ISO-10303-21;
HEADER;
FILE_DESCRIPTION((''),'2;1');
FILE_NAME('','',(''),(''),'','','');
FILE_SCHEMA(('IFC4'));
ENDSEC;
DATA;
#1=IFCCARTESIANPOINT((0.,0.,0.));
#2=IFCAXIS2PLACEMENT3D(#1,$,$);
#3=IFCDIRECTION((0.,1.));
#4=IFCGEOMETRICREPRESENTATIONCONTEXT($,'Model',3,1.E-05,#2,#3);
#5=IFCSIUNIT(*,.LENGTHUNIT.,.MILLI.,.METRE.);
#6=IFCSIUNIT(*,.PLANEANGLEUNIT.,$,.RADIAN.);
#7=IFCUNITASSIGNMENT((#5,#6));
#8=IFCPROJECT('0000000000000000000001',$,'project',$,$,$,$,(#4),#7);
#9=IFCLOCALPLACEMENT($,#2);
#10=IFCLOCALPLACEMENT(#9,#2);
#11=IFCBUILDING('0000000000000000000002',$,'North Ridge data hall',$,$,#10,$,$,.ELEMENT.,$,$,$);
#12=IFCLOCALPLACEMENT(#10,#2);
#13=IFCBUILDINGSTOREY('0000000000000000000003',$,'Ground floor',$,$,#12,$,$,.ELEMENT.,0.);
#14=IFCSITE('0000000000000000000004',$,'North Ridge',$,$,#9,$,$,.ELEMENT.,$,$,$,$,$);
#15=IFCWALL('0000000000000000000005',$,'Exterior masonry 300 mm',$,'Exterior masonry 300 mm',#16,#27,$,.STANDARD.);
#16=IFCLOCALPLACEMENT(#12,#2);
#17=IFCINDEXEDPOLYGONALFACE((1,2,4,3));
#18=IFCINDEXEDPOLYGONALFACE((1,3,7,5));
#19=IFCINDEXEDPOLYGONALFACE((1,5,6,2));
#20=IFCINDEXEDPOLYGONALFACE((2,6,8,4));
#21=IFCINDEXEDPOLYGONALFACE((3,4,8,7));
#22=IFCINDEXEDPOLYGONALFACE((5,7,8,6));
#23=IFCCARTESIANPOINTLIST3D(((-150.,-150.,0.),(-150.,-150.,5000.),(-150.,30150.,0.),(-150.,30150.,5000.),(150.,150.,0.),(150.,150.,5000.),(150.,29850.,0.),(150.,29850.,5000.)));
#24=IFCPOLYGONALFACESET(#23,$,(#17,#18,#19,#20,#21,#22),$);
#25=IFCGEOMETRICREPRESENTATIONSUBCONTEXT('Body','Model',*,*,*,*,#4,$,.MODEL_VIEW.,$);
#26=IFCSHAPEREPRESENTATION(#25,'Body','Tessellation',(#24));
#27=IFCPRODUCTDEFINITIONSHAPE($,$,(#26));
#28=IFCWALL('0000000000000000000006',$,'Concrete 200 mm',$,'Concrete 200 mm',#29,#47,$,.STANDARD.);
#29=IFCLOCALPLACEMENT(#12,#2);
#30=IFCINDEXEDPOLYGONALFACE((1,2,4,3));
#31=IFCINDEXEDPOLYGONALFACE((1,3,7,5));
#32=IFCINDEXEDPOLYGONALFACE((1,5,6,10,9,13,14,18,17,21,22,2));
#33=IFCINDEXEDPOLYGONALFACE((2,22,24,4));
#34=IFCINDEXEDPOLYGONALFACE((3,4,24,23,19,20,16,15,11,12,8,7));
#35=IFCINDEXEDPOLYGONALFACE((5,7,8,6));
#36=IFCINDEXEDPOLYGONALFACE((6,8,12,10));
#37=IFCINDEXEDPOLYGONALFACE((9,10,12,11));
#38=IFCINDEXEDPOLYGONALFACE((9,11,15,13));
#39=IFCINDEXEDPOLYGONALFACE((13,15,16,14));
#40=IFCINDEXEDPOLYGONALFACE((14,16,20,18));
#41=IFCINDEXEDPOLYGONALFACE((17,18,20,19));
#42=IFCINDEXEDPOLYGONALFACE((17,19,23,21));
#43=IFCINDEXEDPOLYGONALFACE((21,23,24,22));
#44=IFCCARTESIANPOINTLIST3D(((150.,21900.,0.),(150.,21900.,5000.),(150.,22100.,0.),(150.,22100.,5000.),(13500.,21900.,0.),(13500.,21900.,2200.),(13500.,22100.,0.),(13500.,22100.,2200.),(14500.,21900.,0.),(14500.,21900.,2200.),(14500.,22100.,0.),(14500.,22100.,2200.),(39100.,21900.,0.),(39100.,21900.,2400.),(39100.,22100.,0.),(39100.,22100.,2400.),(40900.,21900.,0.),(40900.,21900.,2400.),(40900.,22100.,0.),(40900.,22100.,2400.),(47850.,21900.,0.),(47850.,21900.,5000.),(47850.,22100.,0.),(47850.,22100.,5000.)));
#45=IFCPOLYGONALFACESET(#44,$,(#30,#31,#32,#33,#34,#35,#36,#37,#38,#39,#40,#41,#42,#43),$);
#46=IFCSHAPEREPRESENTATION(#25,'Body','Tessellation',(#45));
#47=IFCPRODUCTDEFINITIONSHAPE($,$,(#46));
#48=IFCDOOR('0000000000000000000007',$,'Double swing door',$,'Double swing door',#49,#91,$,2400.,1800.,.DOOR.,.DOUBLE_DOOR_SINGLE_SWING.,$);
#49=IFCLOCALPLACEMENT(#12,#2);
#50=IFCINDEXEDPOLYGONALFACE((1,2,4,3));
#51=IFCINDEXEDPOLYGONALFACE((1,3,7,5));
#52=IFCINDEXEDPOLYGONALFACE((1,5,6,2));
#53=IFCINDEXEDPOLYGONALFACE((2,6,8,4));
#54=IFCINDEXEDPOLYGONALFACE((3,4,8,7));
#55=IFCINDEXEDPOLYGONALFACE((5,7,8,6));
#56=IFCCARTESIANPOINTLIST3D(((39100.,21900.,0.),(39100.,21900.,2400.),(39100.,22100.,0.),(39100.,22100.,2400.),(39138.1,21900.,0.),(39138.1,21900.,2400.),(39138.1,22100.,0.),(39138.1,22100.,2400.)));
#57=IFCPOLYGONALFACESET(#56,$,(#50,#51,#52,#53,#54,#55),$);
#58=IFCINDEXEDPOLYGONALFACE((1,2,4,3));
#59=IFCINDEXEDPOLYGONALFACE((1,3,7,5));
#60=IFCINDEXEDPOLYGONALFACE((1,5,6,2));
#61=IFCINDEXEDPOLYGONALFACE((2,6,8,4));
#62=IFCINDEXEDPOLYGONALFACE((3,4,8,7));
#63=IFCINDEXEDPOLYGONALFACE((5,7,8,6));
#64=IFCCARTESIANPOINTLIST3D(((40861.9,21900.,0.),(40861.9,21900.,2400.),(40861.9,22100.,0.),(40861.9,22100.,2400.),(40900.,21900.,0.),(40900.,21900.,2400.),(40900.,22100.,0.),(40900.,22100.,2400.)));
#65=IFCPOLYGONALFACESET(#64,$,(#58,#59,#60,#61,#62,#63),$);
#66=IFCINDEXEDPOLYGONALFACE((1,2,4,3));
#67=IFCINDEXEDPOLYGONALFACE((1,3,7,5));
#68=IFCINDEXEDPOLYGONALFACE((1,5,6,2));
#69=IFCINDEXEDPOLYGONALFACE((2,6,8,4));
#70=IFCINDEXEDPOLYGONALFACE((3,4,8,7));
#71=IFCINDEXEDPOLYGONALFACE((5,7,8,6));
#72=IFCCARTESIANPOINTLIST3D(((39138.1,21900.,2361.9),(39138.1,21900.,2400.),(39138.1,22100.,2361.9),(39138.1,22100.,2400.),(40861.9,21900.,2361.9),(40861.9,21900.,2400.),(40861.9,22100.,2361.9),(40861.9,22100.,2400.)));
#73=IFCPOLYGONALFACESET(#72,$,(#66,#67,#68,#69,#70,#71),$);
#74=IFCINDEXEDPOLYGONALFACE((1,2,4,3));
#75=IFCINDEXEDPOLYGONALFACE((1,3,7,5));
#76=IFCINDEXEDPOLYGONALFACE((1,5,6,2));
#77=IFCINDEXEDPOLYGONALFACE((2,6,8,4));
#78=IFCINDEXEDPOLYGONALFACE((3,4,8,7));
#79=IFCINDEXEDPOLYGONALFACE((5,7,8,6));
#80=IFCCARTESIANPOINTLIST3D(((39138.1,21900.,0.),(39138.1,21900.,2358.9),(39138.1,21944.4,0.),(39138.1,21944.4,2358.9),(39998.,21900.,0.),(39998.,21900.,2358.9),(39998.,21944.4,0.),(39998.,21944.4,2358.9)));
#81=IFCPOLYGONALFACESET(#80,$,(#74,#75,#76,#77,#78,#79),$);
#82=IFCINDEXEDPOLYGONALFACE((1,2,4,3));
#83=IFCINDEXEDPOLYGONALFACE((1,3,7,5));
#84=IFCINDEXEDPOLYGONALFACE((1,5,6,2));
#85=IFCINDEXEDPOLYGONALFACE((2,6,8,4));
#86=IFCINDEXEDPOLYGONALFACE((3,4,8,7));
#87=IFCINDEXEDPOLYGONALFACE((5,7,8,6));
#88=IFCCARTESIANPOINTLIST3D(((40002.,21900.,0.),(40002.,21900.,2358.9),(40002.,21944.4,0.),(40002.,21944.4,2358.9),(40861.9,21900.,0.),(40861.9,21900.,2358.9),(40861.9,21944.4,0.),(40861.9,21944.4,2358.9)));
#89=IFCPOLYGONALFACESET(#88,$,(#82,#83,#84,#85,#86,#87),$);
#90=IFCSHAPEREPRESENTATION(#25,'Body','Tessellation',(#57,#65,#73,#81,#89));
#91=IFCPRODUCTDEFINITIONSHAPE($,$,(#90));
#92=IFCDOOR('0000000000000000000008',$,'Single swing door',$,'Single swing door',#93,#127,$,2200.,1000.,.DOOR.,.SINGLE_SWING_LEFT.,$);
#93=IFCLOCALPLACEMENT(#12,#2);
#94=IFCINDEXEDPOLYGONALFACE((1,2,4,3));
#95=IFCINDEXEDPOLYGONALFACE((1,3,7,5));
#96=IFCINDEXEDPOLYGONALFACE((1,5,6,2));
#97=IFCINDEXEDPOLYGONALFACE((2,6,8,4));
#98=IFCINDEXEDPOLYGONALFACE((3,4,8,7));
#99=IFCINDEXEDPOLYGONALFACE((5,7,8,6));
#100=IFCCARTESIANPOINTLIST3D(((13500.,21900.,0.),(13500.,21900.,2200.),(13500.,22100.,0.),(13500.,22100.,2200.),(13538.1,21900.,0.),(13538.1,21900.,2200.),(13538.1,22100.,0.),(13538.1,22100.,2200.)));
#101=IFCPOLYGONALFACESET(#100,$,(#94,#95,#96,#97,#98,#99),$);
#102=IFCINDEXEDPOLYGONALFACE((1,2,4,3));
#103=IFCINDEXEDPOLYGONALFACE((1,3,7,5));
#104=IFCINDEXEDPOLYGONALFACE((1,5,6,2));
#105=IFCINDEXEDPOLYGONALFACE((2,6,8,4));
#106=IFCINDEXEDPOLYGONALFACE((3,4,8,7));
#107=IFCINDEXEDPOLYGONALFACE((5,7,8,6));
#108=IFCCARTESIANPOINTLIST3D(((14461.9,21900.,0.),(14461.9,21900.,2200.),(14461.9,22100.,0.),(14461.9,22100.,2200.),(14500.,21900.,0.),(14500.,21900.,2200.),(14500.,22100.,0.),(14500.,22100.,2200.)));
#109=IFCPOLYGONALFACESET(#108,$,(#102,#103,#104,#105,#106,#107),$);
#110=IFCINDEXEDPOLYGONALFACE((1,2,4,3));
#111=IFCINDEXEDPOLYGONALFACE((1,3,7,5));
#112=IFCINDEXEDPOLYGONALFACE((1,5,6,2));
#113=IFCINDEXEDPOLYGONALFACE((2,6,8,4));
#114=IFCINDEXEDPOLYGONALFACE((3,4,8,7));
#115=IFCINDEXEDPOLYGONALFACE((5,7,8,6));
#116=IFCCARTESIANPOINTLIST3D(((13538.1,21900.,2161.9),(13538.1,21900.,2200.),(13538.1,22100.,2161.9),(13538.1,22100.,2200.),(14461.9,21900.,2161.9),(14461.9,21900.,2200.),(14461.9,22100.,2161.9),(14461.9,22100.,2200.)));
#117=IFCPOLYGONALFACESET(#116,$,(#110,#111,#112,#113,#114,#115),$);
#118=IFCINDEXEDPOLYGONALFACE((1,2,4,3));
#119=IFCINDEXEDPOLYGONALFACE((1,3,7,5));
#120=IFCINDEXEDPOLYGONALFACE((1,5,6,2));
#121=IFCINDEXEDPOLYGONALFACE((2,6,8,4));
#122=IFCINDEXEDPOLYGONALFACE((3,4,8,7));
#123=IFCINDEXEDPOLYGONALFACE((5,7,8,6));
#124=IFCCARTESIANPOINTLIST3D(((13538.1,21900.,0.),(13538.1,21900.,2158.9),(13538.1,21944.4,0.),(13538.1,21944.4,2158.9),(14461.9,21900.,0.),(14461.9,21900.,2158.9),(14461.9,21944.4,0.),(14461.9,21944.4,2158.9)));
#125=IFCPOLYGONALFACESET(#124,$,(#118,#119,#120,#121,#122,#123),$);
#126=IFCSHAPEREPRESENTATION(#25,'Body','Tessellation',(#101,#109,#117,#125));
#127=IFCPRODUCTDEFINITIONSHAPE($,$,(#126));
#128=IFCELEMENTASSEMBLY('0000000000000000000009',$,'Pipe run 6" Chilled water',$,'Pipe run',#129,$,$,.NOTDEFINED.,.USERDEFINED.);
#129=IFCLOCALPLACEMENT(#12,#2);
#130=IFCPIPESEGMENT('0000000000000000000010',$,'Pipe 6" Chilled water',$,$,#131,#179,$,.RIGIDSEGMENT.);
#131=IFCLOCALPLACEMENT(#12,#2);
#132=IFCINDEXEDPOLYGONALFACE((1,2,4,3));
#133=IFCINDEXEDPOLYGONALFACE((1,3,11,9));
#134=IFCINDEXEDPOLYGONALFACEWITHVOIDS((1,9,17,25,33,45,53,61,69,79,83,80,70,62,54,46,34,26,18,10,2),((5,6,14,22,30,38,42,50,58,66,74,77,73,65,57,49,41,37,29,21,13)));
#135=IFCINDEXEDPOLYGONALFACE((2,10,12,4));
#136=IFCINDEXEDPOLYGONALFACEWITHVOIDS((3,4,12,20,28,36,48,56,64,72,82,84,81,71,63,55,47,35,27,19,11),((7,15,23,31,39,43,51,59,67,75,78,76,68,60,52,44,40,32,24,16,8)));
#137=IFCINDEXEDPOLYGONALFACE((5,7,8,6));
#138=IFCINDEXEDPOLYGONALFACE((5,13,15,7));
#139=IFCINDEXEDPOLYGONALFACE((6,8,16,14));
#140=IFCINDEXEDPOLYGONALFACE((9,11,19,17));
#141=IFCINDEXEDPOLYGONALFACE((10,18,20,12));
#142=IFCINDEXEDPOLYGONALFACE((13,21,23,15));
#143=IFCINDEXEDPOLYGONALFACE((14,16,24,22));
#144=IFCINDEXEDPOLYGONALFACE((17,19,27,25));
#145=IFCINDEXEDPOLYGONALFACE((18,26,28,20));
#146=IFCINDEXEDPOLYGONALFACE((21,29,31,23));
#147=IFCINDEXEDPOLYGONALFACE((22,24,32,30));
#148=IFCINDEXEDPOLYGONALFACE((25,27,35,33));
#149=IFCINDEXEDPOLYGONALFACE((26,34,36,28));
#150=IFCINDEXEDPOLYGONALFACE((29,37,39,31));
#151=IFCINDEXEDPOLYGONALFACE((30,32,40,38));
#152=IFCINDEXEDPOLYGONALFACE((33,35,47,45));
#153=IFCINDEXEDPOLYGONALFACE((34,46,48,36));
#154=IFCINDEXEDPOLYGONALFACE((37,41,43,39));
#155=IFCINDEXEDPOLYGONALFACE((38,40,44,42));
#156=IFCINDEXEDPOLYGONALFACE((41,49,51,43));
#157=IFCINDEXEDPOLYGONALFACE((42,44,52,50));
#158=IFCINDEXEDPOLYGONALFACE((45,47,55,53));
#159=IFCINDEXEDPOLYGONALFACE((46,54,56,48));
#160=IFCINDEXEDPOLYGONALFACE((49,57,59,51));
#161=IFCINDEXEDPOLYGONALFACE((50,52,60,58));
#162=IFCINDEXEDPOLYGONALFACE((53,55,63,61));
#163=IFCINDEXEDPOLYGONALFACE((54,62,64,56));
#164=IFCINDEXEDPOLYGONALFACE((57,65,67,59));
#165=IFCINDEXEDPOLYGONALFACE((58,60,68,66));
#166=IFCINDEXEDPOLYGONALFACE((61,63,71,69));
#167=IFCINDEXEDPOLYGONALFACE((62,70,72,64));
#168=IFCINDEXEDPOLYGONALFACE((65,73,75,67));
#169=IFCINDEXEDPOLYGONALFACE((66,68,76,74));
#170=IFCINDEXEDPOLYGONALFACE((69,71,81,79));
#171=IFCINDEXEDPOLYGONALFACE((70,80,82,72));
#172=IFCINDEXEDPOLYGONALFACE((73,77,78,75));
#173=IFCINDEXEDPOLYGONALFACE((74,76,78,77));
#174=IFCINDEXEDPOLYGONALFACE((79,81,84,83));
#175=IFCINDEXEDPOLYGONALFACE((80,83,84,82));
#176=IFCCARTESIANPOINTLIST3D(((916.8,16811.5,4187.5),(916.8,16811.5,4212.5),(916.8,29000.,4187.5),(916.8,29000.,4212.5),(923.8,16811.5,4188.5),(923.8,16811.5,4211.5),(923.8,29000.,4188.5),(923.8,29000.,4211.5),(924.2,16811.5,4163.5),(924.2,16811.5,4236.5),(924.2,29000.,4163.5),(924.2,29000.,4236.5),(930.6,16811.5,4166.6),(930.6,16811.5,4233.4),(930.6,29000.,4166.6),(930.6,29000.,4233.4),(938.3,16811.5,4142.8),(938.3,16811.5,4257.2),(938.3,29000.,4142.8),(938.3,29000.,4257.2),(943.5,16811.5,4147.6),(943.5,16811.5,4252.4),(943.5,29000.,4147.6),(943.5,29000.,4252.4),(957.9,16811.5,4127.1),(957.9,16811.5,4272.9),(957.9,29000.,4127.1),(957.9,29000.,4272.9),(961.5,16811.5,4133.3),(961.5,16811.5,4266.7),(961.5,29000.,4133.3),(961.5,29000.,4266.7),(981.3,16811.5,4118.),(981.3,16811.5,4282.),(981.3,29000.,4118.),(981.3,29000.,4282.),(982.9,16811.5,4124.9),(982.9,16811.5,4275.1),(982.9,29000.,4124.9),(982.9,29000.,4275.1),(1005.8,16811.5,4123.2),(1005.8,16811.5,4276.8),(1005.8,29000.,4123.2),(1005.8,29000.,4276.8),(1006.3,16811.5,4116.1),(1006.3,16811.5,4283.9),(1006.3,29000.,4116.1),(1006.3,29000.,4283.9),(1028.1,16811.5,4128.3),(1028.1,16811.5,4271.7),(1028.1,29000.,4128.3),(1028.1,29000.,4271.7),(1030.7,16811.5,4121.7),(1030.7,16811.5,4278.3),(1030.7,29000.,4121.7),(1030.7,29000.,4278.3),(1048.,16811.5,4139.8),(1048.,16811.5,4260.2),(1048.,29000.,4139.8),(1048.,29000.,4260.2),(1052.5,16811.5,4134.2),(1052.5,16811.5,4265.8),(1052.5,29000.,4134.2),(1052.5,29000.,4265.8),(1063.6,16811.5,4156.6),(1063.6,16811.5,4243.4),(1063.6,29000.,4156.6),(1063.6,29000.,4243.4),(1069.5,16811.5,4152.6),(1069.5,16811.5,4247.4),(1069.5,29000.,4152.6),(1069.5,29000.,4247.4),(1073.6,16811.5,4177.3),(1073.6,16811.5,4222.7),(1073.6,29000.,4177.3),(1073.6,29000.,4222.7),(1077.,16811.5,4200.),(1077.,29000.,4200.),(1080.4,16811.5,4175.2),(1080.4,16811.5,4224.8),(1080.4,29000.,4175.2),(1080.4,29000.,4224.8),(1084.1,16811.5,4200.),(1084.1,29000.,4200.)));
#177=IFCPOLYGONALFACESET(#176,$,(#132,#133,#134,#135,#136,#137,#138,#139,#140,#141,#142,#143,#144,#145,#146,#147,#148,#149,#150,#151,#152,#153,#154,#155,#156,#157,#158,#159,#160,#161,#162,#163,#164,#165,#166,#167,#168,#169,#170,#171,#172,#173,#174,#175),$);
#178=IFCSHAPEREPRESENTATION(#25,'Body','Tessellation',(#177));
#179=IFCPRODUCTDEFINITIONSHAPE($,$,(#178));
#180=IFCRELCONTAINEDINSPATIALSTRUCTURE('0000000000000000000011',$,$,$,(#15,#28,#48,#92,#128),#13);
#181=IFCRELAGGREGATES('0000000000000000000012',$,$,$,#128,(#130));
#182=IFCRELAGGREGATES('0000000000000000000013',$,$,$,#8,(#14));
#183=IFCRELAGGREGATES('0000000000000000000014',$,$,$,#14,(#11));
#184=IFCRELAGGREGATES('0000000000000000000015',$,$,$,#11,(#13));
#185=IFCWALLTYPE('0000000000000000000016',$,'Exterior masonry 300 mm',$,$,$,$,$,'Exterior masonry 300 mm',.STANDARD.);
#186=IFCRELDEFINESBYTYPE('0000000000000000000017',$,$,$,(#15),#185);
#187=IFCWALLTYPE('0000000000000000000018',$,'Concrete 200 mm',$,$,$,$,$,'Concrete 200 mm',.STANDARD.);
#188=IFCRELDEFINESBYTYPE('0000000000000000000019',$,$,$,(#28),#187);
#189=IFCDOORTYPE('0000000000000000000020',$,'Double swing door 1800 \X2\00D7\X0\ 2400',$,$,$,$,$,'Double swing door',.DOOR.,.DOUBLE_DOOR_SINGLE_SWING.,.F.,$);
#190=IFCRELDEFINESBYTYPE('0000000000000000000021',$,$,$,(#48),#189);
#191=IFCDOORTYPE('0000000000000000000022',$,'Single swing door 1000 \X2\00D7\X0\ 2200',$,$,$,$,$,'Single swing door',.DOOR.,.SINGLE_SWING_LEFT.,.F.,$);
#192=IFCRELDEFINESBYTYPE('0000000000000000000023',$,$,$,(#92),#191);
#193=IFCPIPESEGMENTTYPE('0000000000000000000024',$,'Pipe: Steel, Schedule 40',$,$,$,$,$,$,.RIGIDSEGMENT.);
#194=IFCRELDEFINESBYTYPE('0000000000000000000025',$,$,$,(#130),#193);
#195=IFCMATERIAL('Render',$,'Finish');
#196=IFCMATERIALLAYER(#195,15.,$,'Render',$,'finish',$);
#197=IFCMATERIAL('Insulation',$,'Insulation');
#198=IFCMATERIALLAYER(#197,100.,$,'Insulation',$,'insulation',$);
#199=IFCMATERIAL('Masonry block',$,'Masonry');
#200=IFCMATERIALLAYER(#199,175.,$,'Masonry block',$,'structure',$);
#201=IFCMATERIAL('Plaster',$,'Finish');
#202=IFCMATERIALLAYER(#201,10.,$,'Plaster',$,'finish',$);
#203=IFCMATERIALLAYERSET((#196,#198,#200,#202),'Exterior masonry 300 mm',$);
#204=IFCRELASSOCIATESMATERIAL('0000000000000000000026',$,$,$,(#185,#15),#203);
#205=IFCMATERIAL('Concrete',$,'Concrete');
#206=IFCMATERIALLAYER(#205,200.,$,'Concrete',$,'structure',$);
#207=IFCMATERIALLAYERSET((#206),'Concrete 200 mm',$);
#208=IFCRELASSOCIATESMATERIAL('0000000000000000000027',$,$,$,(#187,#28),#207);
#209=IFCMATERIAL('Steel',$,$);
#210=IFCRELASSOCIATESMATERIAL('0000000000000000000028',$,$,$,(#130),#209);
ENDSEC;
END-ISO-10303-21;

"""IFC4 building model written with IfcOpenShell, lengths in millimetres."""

from ifc_helpers import new_model, si_unit, direction, frame, origin, origin_with_axes, origin_2d, place, context, subcontext, project, spatial, polyline, hollow_circle, outline, extrude, material, layer, layer_set, layer_usage, type_object, element, fill, aggregate, save


model = new_model("IFC4")

# Units and contexts
model_context = context("Model", 3, precision=1e-05, world=origin(), true_north=direction((0.0, 1.0)))
body_context = subcontext(model_context, "Body", "Model", "MODEL_VIEW")
ifc_project = project(units=[si_unit("LENGTHUNIT", "METRE", prefix="MILLI"), si_unit("PLANEANGLEUNIT", "RADIAN")], contexts=[model_context])

# Site, building, storey
site_placement = place(None, origin())
site = spatial("IfcSite", under=ifc_project, at=site_placement, Name="North Ridge", CompositionType="ELEMENT")
building_placement = place(site_placement, origin())
building = spatial("IfcBuilding", under=site, at=building_placement, Name="North Ridge data hall", CompositionType="ELEMENT")
storey_placement = place(building_placement, origin())
storey = spatial("IfcBuildingStorey", under=building, at=storey_placement, Name="Ground floor", CompositionType="ELEMENT", Elevation=0.0)

# Wall
ifc_material_1 = material(Name="Render", Category="Finish")
ifc_layer_1 = layer(ifc_material_1, 15.0, Name="Render", Category="finish")
ifc_material_2 = material(Name="Insulation", Category="Insulation")
ifc_layer_2 = layer(ifc_material_2, 100.0, Name="Insulation", Category="insulation")
ifc_material_3 = material(Name="Masonry block", Category="Masonry")
ifc_layer_3 = layer(ifc_material_3, 175.0, Name="Masonry block", Category="structure")
ifc_material_4 = material(Name="Plaster", Category="Finish")
ifc_layer_4 = layer(ifc_material_4, 10.0, Name="Plaster", Category="finish")
ifc_layer_set_1 = layer_set([ifc_layer_1, ifc_layer_2, ifc_layer_3, ifc_layer_4], Name="Exterior masonry 300 mm")
ifc_layer_usage_1 = layer_usage(ifc_layer_set_1, "AXIS2", "POSITIVE", -150.0)
wall_type_1 = type_object("IfcWallType", Name="Exterior masonry 300 mm", ElementType="Exterior masonry 300 mm", PredefinedType="STANDARD", material=ifc_layer_set_1)
wall_1_placement = place(storey_placement, frame((0.0, 30000.0, 0.0), z_axis=(0.0, 0.0, 1.0), x_axis=(0.0, -1.0, 0.0)))
element("IfcWall", 1, at=wall_1_placement, inside=storey, type_object=wall_type_1, material=ifc_layer_usage_1, Name="Exterior masonry 300 mm", ObjectType="Exterior masonry 300 mm", PredefinedType="STANDARD", context=body_context, shape_type="SweptSolid", body=[
    extrude(outline(polyline([(-150.0, -150.0), (30150.0, -150.0), (29850.0, 150.0), (150.0, 150.0), (-150.0, -150.0)])), origin(), (0.0, 0.0, 1.0), 5000.0),
])

# Wall, openings, doors
ifc_material_5 = material(Name="Concrete", Category="Concrete")
ifc_layer_5 = layer(ifc_material_5, 200.0, Name="Concrete", Category="structure")
ifc_layer_set_2 = layer_set([ifc_layer_5], Name="Concrete 200 mm")
ifc_layer_usage_2 = layer_usage(ifc_layer_set_2, "AXIS2", "NEGATIVE", 100.0)
wall_type_2 = type_object("IfcWallType", Name="Concrete 200 mm", ElementType="Concrete 200 mm", PredefinedType="STANDARD", material=ifc_layer_set_2)
wall_2_placement = place(storey_placement, frame((0.0, 22000.0, 0.0), z_axis=(0.0, 0.0, 1.0), x_axis=(1.0, 0.0, 0.0)))
wall_2 = element("IfcWall", 2, at=wall_2_placement, inside=storey, type_object=wall_type_2, material=ifc_layer_usage_2, Name="Concrete 200 mm", ObjectType="Concrete 200 mm", PredefinedType="STANDARD", context=body_context, shape_type="SweptSolid", body=[
    extrude(outline(polyline([(150.0, -100.0), (47850.0, -100.0), (47850.0, 100.0), (150.0, 100.0), (150.0, -100.0)])), origin(), (0.0, 0.0, 1.0), 5000.0),
])
opening_1_placement = place(wall_2_placement, frame((39100.0, 0.0, 0.0), z_axis=(0.0, 0.0, 1.0), x_axis=(1.0, 0.0, 0.0)))
opening_1 = element("IfcOpeningElement", 3, at=opening_1_placement, cuts=wall_2, PredefinedType="OPENING", context=body_context, shape_type="SweptSolid", body=[
    extrude(outline(polyline([(0.0, -110.0), (1800.0, -110.0), (1800.0, 110.0), (0.0, 110.0), (0.0, -110.0)])), origin(), (0.0, 0.0, 1.0), 2400.0),
])
opening_2_placement = place(wall_2_placement, frame((13500.0, 0.0, 0.0), z_axis=(0.0, 0.0, 1.0), x_axis=(1.0, 0.0, 0.0)))
opening_2 = element("IfcOpeningElement", 4, at=opening_2_placement, cuts=wall_2, PredefinedType="OPENING", context=body_context, shape_type="SweptSolid", body=[
    extrude(outline(polyline([(0.0, -110.0), (1000.0, -110.0), (1000.0, 110.0), (0.0, 110.0), (0.0, -110.0)])), origin(), (0.0, 0.0, 1.0), 2200.0),
])
door_type_1 = type_object("IfcDoorType", Name="Double swing door 1800 × 2400", ElementType="Double swing door", OperationType="DOUBLE_DOOR_SINGLE_SWING", ParameterTakesPrecedence=False, PredefinedType="DOOR")
door_1_placement = place(opening_1_placement, origin_with_axes())
door_1 = element("IfcDoor", 5, at=door_1_placement, inside=storey, type_object=door_type_1, Name="Double swing door", ObjectType="Double swing door", OperationType="DOUBLE_DOOR_SINGLE_SWING", OverallHeight=2400.0, OverallWidth=1800.0, PredefinedType="DOOR", context=body_context, shape_type="SweptSolid", body=[
    extrude(outline(polyline([(0.0, -100.0), (38.1, -100.0), (38.1, 100.0), (0.0, 100.0), (0.0, -100.0)])), origin(), (0.0, 0.0, 1.0), 2400.0),
    extrude(outline(polyline([(1761.9, -100.0), (1800.0, -100.0), (1800.0, 100.0), (1761.9, 100.0), (1761.9, -100.0)])), origin(), (0.0, 0.0, 1.0), 2400.0),
    extrude(outline(polyline([(38.1, -100.0), (1761.9, -100.0), (1761.9, 100.0), (38.1, 100.0), (38.1, -100.0)])), frame((0.0, 0.0, 2361.9)), (0.0, 0.0, 1.0), 38.1),
    extrude(outline(polyline([(38.1, -100.0), (898.0, -100.0), (898.0, -55.5), (38.1, -55.5), (38.1, -100.0)])), origin(), (0.0, 0.0, 1.0), 2358.9),
    extrude(outline(polyline([(902.0, -100.0), (1761.9, -100.0), (1761.9, -55.5), (902.0, -55.5), (902.0, -100.0)])), origin(), (0.0, 0.0, 1.0), 2358.9),
])
fill(opening_1, door_1)
door_type_2 = type_object("IfcDoorType", Name="Single swing door 1000 × 2200", ElementType="Single swing door", OperationType="SINGLE_SWING_LEFT", ParameterTakesPrecedence=False, PredefinedType="DOOR")
door_2_placement = place(opening_2_placement, origin_with_axes())
door_2 = element("IfcDoor", 6, at=door_2_placement, inside=storey, type_object=door_type_2, Name="Single swing door", ObjectType="Single swing door", OperationType="SINGLE_SWING_LEFT", OverallHeight=2200.0, OverallWidth=1000.0, PredefinedType="DOOR", context=body_context, shape_type="SweptSolid", body=[
    extrude(outline(polyline([(0.0, -100.0), (38.1, -100.0), (38.1, 100.0), (0.0, 100.0), (0.0, -100.0)])), origin(), (0.0, 0.0, 1.0), 2200.0),
    extrude(outline(polyline([(961.9, -100.0), (1000.0, -100.0), (1000.0, 100.0), (961.9, 100.0), (961.9, -100.0)])), origin(), (0.0, 0.0, 1.0), 2200.0),
    extrude(outline(polyline([(38.1, -100.0), (961.9, -100.0), (961.9, 100.0), (38.1, 100.0), (38.1, -100.0)])), frame((0.0, 0.0, 2161.9)), (0.0, 0.0, 1.0), 38.1),
    extrude(outline(polyline([(38.1, -100.0), (961.9, -100.0), (961.9, -55.5), (38.1, -55.5), (38.1, -100.0)])), origin(), (0.0, 0.0, 1.0), 2158.9),
])
fill(opening_2, door_2)

# Element assembly, pipe segment
assembly_1_placement = place(storey_placement, origin_with_axes())
assembly_1 = element("IfcElementAssembly", 7, at=assembly_1_placement, inside=storey, Name="Pipe run 6\" Chilled water", ObjectType="Pipe run", AssemblyPlace="NOTDEFINED", PredefinedType="USERDEFINED")
ifc_material_6 = material(Name="Steel")
pipe_segment_type = type_object("IfcPipeSegmentType", Name="Pipe: Steel, Schedule 40", PredefinedType="RIGIDSEGMENT")
pipe_segment_1_placement = place(storey_placement, origin_with_axes())
pipe_segment_1 = element("IfcPipeSegment", 8, at=pipe_segment_1_placement, type_object=pipe_segment_type, material=ifc_material_6, Name="Pipe 6\" Chilled water", PredefinedType="RIGIDSEGMENT", context=body_context, shape_type="SweptSolid", body=[
    extrude(hollow_circle(Radius=84.1, WallThickness=7.1, at=origin_2d()), frame((1000.0, 29000.0, 4200.0), z_axis=(0.0, -1.0, 0.0), x_axis=(1.0, 0.0, 0.0)), (0.0, 0.0, 1.0), 12188.5),
])

aggregate(assembly_1, [pipe_segment_1])

save(model, "model.ifc")
